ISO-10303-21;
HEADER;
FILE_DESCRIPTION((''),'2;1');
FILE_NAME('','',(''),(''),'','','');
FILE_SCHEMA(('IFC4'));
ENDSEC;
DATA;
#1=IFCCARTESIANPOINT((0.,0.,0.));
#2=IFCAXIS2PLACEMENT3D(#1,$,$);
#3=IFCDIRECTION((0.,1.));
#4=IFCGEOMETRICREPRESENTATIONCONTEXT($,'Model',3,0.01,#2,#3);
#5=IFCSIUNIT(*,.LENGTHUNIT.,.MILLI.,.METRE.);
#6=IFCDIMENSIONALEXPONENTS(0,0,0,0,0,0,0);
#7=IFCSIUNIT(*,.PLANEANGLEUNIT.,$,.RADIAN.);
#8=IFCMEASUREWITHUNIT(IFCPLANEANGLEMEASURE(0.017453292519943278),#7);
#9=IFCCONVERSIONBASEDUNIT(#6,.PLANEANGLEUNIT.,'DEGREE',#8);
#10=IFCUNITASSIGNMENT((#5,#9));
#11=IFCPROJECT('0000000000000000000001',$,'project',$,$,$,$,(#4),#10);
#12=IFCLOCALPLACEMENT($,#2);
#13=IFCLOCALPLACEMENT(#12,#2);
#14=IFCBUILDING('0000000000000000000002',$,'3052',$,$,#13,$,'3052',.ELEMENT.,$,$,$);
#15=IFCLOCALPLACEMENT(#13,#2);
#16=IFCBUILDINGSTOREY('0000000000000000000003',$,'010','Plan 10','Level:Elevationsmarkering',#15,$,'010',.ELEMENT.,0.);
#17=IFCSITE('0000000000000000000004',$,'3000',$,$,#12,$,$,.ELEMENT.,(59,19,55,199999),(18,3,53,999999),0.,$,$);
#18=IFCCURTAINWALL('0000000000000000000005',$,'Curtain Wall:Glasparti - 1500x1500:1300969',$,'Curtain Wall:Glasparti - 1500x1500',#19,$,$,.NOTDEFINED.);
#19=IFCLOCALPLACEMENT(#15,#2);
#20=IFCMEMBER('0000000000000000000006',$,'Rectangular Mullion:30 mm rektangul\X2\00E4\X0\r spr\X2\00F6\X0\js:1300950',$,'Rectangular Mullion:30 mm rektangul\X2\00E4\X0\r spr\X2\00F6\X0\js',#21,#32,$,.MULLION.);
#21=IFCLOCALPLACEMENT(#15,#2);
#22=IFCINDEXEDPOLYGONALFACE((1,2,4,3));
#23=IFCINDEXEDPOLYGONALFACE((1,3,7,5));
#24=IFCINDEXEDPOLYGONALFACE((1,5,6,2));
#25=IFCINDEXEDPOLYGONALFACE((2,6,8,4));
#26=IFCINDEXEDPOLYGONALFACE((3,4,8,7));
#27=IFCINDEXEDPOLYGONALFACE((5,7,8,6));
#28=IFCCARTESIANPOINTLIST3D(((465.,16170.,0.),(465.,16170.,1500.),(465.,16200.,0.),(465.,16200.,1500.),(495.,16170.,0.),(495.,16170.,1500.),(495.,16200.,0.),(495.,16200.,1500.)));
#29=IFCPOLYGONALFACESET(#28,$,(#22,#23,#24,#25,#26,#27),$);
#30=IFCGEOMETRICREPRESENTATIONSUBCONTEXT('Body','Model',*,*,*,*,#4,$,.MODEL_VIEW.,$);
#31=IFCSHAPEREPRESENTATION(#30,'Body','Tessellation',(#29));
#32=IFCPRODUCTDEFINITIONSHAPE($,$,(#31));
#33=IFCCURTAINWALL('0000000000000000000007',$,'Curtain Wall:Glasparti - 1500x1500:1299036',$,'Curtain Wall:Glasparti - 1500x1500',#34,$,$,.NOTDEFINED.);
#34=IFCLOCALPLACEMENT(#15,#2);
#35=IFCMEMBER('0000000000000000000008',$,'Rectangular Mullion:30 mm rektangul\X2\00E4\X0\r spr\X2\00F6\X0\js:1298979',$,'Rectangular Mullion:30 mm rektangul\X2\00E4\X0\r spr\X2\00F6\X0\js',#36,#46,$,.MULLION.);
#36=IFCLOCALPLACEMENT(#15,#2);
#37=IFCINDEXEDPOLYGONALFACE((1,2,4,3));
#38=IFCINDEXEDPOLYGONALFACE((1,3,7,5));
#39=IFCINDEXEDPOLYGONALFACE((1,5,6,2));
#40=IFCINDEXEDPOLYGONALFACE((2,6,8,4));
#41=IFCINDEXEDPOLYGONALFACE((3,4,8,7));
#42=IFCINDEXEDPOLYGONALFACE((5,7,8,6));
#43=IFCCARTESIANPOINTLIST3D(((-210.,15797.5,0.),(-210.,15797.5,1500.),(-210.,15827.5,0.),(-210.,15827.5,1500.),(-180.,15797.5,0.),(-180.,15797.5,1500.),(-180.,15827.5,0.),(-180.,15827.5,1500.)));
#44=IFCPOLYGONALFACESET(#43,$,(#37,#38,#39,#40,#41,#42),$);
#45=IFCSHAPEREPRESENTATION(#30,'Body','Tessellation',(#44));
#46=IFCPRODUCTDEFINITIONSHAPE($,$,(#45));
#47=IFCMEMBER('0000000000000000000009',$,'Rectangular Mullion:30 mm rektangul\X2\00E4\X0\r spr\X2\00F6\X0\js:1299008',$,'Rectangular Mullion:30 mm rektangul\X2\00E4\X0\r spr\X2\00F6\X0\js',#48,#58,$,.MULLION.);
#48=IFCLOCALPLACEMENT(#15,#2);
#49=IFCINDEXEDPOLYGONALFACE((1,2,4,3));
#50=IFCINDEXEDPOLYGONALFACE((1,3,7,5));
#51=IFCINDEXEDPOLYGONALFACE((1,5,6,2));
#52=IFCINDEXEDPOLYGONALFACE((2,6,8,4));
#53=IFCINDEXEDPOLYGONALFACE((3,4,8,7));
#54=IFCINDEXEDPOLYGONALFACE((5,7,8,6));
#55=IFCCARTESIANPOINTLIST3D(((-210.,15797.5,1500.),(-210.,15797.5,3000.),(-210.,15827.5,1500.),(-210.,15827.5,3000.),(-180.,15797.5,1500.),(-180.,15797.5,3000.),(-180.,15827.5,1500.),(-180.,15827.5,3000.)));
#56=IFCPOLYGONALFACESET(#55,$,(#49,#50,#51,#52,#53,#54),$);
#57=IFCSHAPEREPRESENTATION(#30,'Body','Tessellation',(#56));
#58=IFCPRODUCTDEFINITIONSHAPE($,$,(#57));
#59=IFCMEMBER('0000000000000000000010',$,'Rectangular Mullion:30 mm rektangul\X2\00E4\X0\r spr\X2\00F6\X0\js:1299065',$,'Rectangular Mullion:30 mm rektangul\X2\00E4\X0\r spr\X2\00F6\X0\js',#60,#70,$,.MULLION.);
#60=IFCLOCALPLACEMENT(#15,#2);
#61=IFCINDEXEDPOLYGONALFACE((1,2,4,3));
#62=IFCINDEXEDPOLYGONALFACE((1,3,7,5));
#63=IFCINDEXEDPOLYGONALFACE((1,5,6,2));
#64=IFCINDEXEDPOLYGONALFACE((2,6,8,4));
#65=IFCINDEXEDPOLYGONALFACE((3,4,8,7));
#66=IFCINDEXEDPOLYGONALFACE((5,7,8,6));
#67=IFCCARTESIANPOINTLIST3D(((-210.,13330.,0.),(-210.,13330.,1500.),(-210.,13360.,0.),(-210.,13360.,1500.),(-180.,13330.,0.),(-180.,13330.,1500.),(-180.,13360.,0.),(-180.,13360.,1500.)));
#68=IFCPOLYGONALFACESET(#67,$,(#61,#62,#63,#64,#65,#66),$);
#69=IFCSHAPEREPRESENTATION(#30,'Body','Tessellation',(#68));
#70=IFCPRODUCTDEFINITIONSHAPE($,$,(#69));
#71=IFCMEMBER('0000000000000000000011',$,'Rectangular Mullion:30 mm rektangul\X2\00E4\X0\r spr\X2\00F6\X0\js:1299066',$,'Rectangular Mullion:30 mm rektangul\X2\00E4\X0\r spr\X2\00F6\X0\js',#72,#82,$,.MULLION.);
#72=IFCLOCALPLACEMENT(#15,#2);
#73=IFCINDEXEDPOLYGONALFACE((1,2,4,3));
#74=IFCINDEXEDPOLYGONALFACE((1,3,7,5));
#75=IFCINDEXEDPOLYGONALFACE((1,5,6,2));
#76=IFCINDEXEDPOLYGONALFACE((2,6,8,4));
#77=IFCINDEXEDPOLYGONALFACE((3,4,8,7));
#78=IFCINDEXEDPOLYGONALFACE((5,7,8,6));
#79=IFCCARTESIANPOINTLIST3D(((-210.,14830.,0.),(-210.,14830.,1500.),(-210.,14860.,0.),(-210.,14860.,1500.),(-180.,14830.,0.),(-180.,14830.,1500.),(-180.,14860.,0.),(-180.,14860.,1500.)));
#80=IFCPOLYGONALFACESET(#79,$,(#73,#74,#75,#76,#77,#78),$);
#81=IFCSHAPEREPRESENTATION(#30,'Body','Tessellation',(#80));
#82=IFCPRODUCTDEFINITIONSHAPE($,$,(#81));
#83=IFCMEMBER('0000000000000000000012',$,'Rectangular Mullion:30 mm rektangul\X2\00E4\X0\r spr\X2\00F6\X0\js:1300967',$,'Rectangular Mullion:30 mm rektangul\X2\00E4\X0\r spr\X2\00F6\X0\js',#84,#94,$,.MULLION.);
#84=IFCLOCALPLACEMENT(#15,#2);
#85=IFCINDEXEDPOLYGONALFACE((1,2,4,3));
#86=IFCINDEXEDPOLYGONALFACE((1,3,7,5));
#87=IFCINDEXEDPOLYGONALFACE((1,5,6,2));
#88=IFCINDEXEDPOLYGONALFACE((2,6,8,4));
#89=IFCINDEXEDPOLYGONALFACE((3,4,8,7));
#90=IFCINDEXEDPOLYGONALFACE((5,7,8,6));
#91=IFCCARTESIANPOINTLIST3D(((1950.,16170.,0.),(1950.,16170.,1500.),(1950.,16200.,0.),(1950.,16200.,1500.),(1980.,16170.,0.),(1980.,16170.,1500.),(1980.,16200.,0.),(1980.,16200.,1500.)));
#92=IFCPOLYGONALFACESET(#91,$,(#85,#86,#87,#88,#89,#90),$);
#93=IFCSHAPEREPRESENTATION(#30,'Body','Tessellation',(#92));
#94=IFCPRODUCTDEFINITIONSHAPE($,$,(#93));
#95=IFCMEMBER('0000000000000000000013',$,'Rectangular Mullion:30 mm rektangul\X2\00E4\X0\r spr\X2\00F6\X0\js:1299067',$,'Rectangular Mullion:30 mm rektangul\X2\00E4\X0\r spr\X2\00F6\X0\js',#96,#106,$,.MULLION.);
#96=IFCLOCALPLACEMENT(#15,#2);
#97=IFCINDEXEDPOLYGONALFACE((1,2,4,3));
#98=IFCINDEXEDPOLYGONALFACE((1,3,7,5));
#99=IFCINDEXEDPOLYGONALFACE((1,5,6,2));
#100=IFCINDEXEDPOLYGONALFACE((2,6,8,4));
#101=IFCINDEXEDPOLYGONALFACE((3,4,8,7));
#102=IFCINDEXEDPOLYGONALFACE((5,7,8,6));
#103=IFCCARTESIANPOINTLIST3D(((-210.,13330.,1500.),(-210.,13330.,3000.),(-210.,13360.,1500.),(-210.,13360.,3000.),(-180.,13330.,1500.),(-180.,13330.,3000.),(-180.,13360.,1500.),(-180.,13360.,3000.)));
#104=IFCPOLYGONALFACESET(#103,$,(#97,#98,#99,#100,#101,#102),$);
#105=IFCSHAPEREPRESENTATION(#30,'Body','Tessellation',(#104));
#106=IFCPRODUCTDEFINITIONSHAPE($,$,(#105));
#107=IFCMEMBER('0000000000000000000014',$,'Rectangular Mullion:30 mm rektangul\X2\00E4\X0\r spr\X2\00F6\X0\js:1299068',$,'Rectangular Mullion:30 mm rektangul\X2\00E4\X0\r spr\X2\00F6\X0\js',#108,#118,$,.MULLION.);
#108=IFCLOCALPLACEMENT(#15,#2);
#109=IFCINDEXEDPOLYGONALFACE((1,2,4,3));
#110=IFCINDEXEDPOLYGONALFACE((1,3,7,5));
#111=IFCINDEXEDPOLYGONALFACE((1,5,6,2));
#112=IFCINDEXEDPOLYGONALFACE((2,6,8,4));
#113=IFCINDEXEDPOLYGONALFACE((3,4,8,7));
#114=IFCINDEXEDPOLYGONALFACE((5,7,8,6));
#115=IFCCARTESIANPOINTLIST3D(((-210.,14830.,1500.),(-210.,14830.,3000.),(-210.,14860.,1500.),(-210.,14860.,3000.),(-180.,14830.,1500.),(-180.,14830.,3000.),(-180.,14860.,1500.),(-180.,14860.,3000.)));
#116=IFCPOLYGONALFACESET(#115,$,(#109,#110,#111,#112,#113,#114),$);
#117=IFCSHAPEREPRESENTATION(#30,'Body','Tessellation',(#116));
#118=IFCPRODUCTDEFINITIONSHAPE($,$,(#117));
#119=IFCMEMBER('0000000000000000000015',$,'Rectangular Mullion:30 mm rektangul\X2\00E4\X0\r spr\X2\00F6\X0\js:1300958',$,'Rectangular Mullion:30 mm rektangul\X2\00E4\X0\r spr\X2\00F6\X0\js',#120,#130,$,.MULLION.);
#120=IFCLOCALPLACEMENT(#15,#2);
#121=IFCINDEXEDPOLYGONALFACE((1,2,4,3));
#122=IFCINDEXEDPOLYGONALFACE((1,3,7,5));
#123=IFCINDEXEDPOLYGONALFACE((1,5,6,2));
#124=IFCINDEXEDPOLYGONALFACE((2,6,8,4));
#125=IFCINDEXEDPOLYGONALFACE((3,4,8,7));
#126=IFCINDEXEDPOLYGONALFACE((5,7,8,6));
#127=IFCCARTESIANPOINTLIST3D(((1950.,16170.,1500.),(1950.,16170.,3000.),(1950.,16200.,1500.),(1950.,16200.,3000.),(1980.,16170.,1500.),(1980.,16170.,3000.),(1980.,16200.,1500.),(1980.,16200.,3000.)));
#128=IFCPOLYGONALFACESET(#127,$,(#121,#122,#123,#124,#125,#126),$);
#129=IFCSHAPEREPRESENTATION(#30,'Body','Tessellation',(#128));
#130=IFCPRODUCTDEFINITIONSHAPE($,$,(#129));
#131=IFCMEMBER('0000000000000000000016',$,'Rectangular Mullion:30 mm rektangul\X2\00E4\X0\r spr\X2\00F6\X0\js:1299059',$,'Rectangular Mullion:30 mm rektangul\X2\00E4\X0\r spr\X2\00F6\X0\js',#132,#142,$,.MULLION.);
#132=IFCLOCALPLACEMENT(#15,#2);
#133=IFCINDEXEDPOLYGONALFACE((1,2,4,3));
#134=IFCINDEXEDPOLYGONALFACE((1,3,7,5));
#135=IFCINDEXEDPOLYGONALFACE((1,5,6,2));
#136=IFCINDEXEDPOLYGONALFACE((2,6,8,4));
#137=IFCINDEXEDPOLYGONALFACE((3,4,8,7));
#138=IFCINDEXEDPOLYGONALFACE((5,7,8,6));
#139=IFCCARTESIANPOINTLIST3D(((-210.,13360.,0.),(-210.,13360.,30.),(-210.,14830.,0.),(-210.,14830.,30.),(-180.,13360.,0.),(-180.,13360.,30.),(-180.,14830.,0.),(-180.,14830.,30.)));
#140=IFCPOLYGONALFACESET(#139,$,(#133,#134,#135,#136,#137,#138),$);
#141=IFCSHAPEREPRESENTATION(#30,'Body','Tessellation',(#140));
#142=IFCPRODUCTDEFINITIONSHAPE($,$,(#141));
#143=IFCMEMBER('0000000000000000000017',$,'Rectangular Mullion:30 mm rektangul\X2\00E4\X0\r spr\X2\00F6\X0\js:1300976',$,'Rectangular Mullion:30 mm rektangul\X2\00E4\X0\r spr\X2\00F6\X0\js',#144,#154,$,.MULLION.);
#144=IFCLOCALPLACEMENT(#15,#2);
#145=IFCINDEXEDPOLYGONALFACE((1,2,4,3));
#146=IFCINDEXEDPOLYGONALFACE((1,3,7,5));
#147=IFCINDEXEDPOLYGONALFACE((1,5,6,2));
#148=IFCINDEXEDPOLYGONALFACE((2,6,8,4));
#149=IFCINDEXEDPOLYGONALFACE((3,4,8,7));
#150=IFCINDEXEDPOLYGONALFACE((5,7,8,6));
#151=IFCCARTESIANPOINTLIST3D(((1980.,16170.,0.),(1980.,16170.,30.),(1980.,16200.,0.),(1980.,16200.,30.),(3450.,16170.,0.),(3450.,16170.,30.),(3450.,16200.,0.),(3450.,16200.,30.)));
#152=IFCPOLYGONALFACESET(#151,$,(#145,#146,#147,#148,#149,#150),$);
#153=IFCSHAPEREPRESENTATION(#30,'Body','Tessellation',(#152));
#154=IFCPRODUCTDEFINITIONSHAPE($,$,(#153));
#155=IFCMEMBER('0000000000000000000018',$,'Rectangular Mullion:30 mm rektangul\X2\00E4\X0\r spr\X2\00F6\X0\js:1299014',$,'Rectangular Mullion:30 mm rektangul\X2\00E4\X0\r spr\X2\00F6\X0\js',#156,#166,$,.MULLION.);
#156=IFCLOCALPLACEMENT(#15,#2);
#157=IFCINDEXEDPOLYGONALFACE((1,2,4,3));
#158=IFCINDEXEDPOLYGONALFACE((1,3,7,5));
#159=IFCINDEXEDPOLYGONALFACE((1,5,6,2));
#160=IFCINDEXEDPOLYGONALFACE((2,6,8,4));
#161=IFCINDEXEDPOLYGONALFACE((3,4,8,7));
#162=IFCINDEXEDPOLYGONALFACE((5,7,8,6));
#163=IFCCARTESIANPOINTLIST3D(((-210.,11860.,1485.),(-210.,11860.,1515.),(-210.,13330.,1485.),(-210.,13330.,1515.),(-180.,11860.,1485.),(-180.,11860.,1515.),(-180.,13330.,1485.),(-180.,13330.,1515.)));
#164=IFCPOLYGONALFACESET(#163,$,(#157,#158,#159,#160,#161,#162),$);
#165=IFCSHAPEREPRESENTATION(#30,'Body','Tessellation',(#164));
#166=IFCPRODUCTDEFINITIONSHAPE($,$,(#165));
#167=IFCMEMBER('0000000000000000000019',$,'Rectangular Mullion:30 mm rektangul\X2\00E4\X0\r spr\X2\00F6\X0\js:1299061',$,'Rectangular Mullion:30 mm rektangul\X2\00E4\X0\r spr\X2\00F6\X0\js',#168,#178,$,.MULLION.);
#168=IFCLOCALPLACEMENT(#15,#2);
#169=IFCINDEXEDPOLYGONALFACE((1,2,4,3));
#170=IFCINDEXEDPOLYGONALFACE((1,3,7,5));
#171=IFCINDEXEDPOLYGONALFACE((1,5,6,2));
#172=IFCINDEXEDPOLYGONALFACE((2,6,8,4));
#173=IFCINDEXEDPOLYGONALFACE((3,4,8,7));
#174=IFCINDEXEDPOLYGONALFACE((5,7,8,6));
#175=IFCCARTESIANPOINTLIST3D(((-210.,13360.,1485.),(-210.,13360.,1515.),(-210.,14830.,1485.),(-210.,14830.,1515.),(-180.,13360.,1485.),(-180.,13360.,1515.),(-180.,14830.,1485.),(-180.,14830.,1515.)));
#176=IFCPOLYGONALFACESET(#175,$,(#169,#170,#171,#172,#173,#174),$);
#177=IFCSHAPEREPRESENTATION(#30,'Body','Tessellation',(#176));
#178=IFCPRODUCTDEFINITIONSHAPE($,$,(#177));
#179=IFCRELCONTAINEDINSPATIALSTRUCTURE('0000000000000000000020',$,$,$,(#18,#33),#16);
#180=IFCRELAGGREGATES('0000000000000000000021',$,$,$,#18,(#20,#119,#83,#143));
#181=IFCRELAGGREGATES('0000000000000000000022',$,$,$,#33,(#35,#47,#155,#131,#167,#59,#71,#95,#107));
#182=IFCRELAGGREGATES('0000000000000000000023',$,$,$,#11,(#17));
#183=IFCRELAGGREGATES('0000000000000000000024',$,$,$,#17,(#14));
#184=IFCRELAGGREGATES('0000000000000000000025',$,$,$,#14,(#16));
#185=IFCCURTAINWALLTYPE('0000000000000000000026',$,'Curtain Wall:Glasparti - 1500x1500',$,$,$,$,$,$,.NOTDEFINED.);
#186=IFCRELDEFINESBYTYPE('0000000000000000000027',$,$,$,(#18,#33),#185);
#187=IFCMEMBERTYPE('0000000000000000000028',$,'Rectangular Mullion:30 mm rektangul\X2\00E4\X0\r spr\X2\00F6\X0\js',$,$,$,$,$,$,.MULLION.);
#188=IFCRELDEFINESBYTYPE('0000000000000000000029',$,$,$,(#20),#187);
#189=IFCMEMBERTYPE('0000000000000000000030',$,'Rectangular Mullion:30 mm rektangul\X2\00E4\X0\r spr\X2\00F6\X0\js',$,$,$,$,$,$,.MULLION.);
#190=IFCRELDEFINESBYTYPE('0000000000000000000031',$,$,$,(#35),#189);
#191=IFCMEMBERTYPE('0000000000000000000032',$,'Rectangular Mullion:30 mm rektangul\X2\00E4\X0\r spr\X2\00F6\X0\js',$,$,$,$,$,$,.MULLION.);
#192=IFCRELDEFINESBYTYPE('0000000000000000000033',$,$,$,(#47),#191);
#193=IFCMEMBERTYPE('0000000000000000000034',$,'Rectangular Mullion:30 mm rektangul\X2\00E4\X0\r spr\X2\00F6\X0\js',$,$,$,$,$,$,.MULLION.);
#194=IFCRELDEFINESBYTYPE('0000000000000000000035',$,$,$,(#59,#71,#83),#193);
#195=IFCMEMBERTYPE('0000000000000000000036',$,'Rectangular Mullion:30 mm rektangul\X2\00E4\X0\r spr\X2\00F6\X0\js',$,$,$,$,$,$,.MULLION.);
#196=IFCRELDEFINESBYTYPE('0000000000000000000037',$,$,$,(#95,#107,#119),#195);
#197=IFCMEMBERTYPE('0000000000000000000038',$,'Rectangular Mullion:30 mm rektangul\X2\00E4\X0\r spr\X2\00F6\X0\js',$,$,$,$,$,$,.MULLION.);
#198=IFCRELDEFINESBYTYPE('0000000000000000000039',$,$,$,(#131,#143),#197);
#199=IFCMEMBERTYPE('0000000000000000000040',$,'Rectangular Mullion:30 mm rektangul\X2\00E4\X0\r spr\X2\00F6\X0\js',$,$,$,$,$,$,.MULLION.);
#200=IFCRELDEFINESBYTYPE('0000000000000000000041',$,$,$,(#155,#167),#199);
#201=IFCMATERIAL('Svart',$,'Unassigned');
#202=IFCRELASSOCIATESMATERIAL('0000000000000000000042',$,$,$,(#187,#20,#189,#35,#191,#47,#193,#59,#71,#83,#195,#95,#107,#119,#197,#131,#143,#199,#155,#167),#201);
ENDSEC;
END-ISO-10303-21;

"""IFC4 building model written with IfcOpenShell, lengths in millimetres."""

from ifc_helpers import new_model, entity, si_unit, converted_unit, direction, frame, origin, place, context, subcontext, project, spatial, indexed_curve, outline, extrude, source, transform, mapped, material, type_object, type_shapes, element, aggregate, save


model = new_model("IFC4")

# Units and contexts
model_context = context("Model", 3, precision=0.01, world=origin(), true_north=direction((0.0, 1.0)))
body_context = subcontext(model_context, "Body", "Model", "MODEL_VIEW")
ifc_project = project(units=[si_unit("LENGTHUNIT", "METRE", prefix="MILLI"), converted_unit("PLANEANGLEUNIT", "DEGREE", entity("IfcPlaneAngleMeasure", 0.017453292519943278), si_unit("PLANEANGLEUNIT", "RADIAN"), dimensions=[0, 0, 0, 0, 0, 0, 0])], contexts=[model_context])

# Site, building, storey
site_placement = place(None, origin())
site = spatial("IfcSite", under=ifc_project, at=site_placement, Name="3000", CompositionType="ELEMENT", RefLatitude=(59, 19, 55, 199999), RefLongitude=(18, 3, 53, 999999), RefElevation=0.0)
building_placement = place(site_placement, origin())
building = spatial("IfcBuilding", under=site, at=building_placement, Name="3052", LongName="3052", CompositionType="ELEMENT")
storey_placement = place(building_placement, origin())
storey = spatial("IfcBuildingStorey", under=building, at=storey_placement, Name="010", Description="Plan 10", ObjectType="Level:Elevationsmarkering", LongName="010", CompositionType="ELEMENT", Elevation=0.0)

# Curtain wall, member
curtain_wall_type = type_object("IfcCurtainWallType", Name="Curtain Wall:Glasparti - 1500x1500", PredefinedType="NOTDEFINED")
curtain_wall_1_placement = place(storey_placement, origin())
curtain_wall_1 = element("IfcCurtainWall", 1, at=curtain_wall_1_placement, inside=storey, type_object=curtain_wall_type, Name="Curtain Wall:Glasparti - 1500x1500:1300969", ObjectType="Curtain Wall:Glasparti - 1500x1500", PredefinedType="NOTDEFINED")
ifc_material_1 = material(Name="Svart", Category="Unassigned")
member_type_1 = type_object("IfcMemberType", Name="Rectangular Mullion:30 mm rektangulär spröjs", PredefinedType="MULLION", material=ifc_material_1)
shared_shape_1 = source(origin(), body_context, "Body", "SweptSolid", [
    extrude(outline(indexed_curve([(-15.0, -15.0), (15.0, -15.0), (15.0, 15.0), (-15.0, 15.0), (-15.0, -15.0)], self_intersect=False)), frame((-15.0, 0.0, -1500.0), z_axis=(0.0, 0.0, 1.0), x_axis=(-1.0, 0.0, 0.0)), (0.0, 0.0, 1.0), 1500.0),
])
type_shapes(member_type_1, [shared_shape_1])
member_1_placement = place(curtain_wall_1_placement, frame((465.0, 16185.0, 1500.0), z_axis=(0.0, 0.0, 1.0), x_axis=(-1.0, 0.0, 0.0)))
member_1 = element("IfcMember", 2, at=member_1_placement, type_object=member_type_1, material=ifc_material_1, Name="Rectangular Mullion:30 mm rektangulär spröjs:1300950", ObjectType="Rectangular Mullion:30 mm rektangulär spröjs", PredefinedType="MULLION", context=body_context, shape_type="MappedRepresentation", body=[
    mapped(shared_shape_1, transform((0.0, 0.0, 0.0), scale=1.0)),
])

# Curtain wall, members
curtain_wall_2_placement = place(storey_placement, origin())
curtain_wall_2 = element("IfcCurtainWall", 3, at=curtain_wall_2_placement, inside=storey, type_object=curtain_wall_type, Name="Curtain Wall:Glasparti - 1500x1500:1299036", ObjectType="Curtain Wall:Glasparti - 1500x1500", PredefinedType="NOTDEFINED")
member_type_2 = type_object("IfcMemberType", Name="Rectangular Mullion:30 mm rektangulär spröjs", PredefinedType="MULLION", material=ifc_material_1)
shared_shape_2 = source(origin(), body_context, "Body", "SweptSolid", [
    extrude(outline(indexed_curve([(-15.0, -15.0), (15.0, -15.0), (15.0, 15.0), (-15.0, 15.0), (-15.0, -15.0)], self_intersect=False)), frame((-15.0, 0.0, -1500.0), z_axis=(0.0, 0.0, 1.0), x_axis=(-1.0, 0.0, 0.0)), (0.0, 0.0, 1.0), 1500.0),
])
type_shapes(member_type_2, [shared_shape_2])
member_2_placement = place(curtain_wall_2_placement, frame((-195.0, 15827.5, 0.0), z_axis=(0.0, 0.0, -1.0), x_axis=(0.0, 1.0, 0.0)))
member_2 = element("IfcMember", 4, at=member_2_placement, type_object=member_type_2, material=ifc_material_1, Name="Rectangular Mullion:30 mm rektangulär spröjs:1298979", ObjectType="Rectangular Mullion:30 mm rektangulär spröjs", PredefinedType="MULLION", context=body_context, shape_type="MappedRepresentation", body=[
    mapped(shared_shape_2, transform((0.0, 0.0, 0.0), scale=1.0)),
])
member_type_3 = type_object("IfcMemberType", Name="Rectangular Mullion:30 mm rektangulär spröjs", PredefinedType="MULLION", material=ifc_material_1)
shared_shape_3 = source(origin(), body_context, "Body", "SweptSolid", [
    extrude(outline(indexed_curve([(-15.0, -15.0), (15.0, -15.0), (15.0, 15.0), (-15.0, 15.0), (-15.0, -15.0)], self_intersect=False)), frame((-15.0, 0.0, -1500.0), z_axis=(0.0, 0.0, 1.0), x_axis=(-1.0, 0.0, 0.0)), (0.0, 0.0, 1.0), 1500.0),
])
type_shapes(member_type_3, [shared_shape_3])
member_3_placement = place(curtain_wall_2_placement, frame((-195.0, 15827.5, 1500.0), z_axis=(0.0, 0.0, -1.0), x_axis=(0.0, 1.0, 0.0)))
member_3 = element("IfcMember", 5, at=member_3_placement, type_object=member_type_3, material=ifc_material_1, Name="Rectangular Mullion:30 mm rektangulär spröjs:1299008", ObjectType="Rectangular Mullion:30 mm rektangulär spröjs", PredefinedType="MULLION", context=body_context, shape_type="MappedRepresentation", body=[
    mapped(shared_shape_3, transform((0.0, 0.0, 0.0), scale=1.0)),
])
member_type_4 = type_object("IfcMemberType", Name="Rectangular Mullion:30 mm rektangulär spröjs", PredefinedType="MULLION", material=ifc_material_1)
shared_shape_4 = source(origin(), body_context, "Body", "SweptSolid", [
    extrude(outline(indexed_curve([(-15.0, -15.0), (15.0, -15.0), (15.0, 15.0), (-15.0, 15.0), (-15.0, -15.0)], self_intersect=False)), frame((0.0, 0.0, -1500.0), z_axis=(0.0, 0.0, 1.0), x_axis=(-1.0, 0.0, 0.0)), (0.0, 0.0, 1.0), 1500.0),
])
type_shapes(member_type_4, [shared_shape_4])
member_4_placement = place(curtain_wall_2_placement, frame((-195.0, 13345.0, 0.0), z_axis=(0.0, 0.0, -1.0), x_axis=(0.0, 1.0, 0.0)))
member_4 = element("IfcMember", 6, at=member_4_placement, type_object=member_type_4, material=ifc_material_1, Name="Rectangular Mullion:30 mm rektangulär spröjs:1299065", ObjectType="Rectangular Mullion:30 mm rektangulär spröjs", PredefinedType="MULLION", context=body_context, shape_type="MappedRepresentation", body=[
    mapped(shared_shape_4, transform((0.0, 0.0, 0.0), scale=1.0)),
])
member_5_placement = place(curtain_wall_2_placement, frame((-195.0, 14845.0, 0.0), z_axis=(0.0, 0.0, -1.0), x_axis=(0.0, 1.0, 0.0)))
member_5 = element("IfcMember", 7, at=member_5_placement, type_object=member_type_4, material=ifc_material_1, Name="Rectangular Mullion:30 mm rektangulär spröjs:1299066", ObjectType="Rectangular Mullion:30 mm rektangulär spröjs", PredefinedType="MULLION", context=body_context, shape_type="MappedRepresentation", body=[
    mapped(shared_shape_4, transform((0.0, 0.0, 0.0), scale=1.0)),
])

# Members
member_6_placement = place(curtain_wall_1_placement, frame((1965.0, 16185.0, 0.0), z_axis=(0.0, 0.0, -1.0), x_axis=(1.0, 0.0, 0.0)))
member_6 = element("IfcMember", 8, at=member_6_placement, type_object=member_type_4, material=ifc_material_1, Name="Rectangular Mullion:30 mm rektangulär spröjs:1300967", ObjectType="Rectangular Mullion:30 mm rektangulär spröjs", PredefinedType="MULLION", context=body_context, shape_type="MappedRepresentation", body=[
    mapped(shared_shape_4, transform((0.0, 0.0, 0.0), scale=1.0)),
])
member_type_5 = type_object("IfcMemberType", Name="Rectangular Mullion:30 mm rektangulär spröjs", PredefinedType="MULLION", material=ifc_material_1)
shared_shape_5 = source(origin(), body_context, "Body", "SweptSolid", [
    extrude(outline(indexed_curve([(-15.0, -15.0), (15.0, -15.0), (15.0, 15.0), (-15.0, 15.0), (-15.0, -15.0)], self_intersect=False)), frame((0.0, 0.0, -1500.0), z_axis=(0.0, 0.0, 1.0), x_axis=(-1.0, 0.0, 0.0)), (0.0, 0.0, 1.0), 1500.0),
])
type_shapes(member_type_5, [shared_shape_5])
member_7_placement = place(curtain_wall_2_placement, frame((-195.0, 13345.0, 1500.0), z_axis=(0.0, 0.0, -1.0), x_axis=(0.0, 1.0, 0.0)))
member_7 = element("IfcMember", 9, at=member_7_placement, type_object=member_type_5, material=ifc_material_1, Name="Rectangular Mullion:30 mm rektangulär spröjs:1299067", ObjectType="Rectangular Mullion:30 mm rektangulär spröjs", PredefinedType="MULLION", context=body_context, shape_type="MappedRepresentation", body=[
    mapped(shared_shape_5, transform((0.0, 0.0, 0.0), scale=1.0)),
])
member_8_placement = place(curtain_wall_2_placement, frame((-195.0, 14845.0, 1500.0), z_axis=(0.0, 0.0, -1.0), x_axis=(0.0, 1.0, 0.0)))
member_8 = element("IfcMember", 10, at=member_8_placement, type_object=member_type_5, material=ifc_material_1, Name="Rectangular Mullion:30 mm rektangulär spröjs:1299068", ObjectType="Rectangular Mullion:30 mm rektangulär spröjs", PredefinedType="MULLION", context=body_context, shape_type="MappedRepresentation", body=[
    mapped(shared_shape_5, transform((0.0, 0.0, 0.0), scale=1.0)),
])
member_9_placement = place(curtain_wall_1_placement, frame((1965.0, 16185.0, 1500.0), z_axis=(0.0, 0.0, -1.0), x_axis=(1.0, 0.0, 0.0)))
member_9 = element("IfcMember", 11, at=member_9_placement, type_object=member_type_5, material=ifc_material_1, Name="Rectangular Mullion:30 mm rektangulär spröjs:1300958", ObjectType="Rectangular Mullion:30 mm rektangulär spröjs", PredefinedType="MULLION", context=body_context, shape_type="MappedRepresentation", body=[
    mapped(shared_shape_5, transform((0.0, 0.0, 0.0), scale=1.0)),
])
member_type_6 = type_object("IfcMemberType", Name="Rectangular Mullion:30 mm rektangulär spröjs", PredefinedType="MULLION", material=ifc_material_1)
shared_shape_6 = source(origin(), body_context, "Body", "SweptSolid", [
    extrude(outline(indexed_curve([(-15.0, -15.0), (15.0, -15.0), (15.0, 15.0), (-15.0, 15.0), (-15.0, -15.0)], self_intersect=False)), frame((-15.0, 0.0, -1470.0), z_axis=(0.0, 0.0, 1.0), x_axis=(-1.0, 0.0, 0.0)), (0.0, 0.0, 1.0), 1470.0),
])
type_shapes(member_type_6, [shared_shape_6])
member_10_placement = place(curtain_wall_2_placement, frame((-195.0, 13360.0, 0.0), z_axis=(0.0, -1.0, 0.0), x_axis=(0.0, 0.0, -1.0)))
member_10 = element("IfcMember", 12, at=member_10_placement, type_object=member_type_6, material=ifc_material_1, Name="Rectangular Mullion:30 mm rektangulär spröjs:1299059", ObjectType="Rectangular Mullion:30 mm rektangulär spröjs", PredefinedType="MULLION", context=body_context, shape_type="MappedRepresentation", body=[
    mapped(shared_shape_6, transform((0.0, 0.0, 0.0), scale=1.0)),
])
member_11_placement = place(curtain_wall_1_placement, frame((1980.0, 16185.0, 0.0), z_axis=(-1.0, 0.0, 0.0), x_axis=(0.0, 0.0, -1.0)))
member_11 = element("IfcMember", 13, at=member_11_placement, type_object=member_type_6, material=ifc_material_1, Name="Rectangular Mullion:30 mm rektangulär spröjs:1300976", ObjectType="Rectangular Mullion:30 mm rektangulär spröjs", PredefinedType="MULLION", context=body_context, shape_type="MappedRepresentation", body=[
    mapped(shared_shape_6, transform((0.0, 0.0, 0.0), scale=1.0)),
])
member_type_7 = type_object("IfcMemberType", Name="Rectangular Mullion:30 mm rektangulär spröjs", PredefinedType="MULLION", material=ifc_material_1)
shared_shape_7 = source(origin(), body_context, "Body", "SweptSolid", [
    extrude(outline(indexed_curve([(-15.0, -15.0), (15.0, -15.0), (15.0, 15.0), (-15.0, 15.0), (-15.0, -15.0)], self_intersect=False)), frame((0.0, 0.0, -1470.0), z_axis=(0.0, 0.0, 1.0), x_axis=(-1.0, 0.0, 0.0)), (0.0, 0.0, 1.0), 1470.0),
])
type_shapes(member_type_7, [shared_shape_7])
member_12_placement = place(curtain_wall_2_placement, frame((-195.0, 13330.0, 1500.0), z_axis=(0.0, 1.0, 0.0), x_axis=(0.0, 0.0, 1.0)))
member_12 = element("IfcMember", 14, at=member_12_placement, type_object=member_type_7, material=ifc_material_1, Name="Rectangular Mullion:30 mm rektangulär spröjs:1299014", ObjectType="Rectangular Mullion:30 mm rektangulär spröjs", PredefinedType="MULLION", context=body_context, shape_type="MappedRepresentation", body=[
    mapped(shared_shape_7, transform((0.0, 0.0, 0.0), scale=1.0)),
])
member_13_placement = place(curtain_wall_2_placement, frame((-195.0, 14830.0, 1500.0), z_axis=(0.0, 1.0, 0.0), x_axis=(0.0, 0.0, 1.0)))
member_13 = element("IfcMember", 15, at=member_13_placement, type_object=member_type_7, material=ifc_material_1, Name="Rectangular Mullion:30 mm rektangulär spröjs:1299061", ObjectType="Rectangular Mullion:30 mm rektangulär spröjs", PredefinedType="MULLION", context=body_context, shape_type="MappedRepresentation", body=[
    mapped(shared_shape_7, transform((0.0, 0.0, 0.0), scale=1.0)),
])

aggregate(curtain_wall_1, [member_1, member_9, member_6, member_11])
aggregate(curtain_wall_2, [member_2, member_3, member_12, member_10, member_13, member_4, member_5, member_7, member_8])

save(model, "model.ifc")
